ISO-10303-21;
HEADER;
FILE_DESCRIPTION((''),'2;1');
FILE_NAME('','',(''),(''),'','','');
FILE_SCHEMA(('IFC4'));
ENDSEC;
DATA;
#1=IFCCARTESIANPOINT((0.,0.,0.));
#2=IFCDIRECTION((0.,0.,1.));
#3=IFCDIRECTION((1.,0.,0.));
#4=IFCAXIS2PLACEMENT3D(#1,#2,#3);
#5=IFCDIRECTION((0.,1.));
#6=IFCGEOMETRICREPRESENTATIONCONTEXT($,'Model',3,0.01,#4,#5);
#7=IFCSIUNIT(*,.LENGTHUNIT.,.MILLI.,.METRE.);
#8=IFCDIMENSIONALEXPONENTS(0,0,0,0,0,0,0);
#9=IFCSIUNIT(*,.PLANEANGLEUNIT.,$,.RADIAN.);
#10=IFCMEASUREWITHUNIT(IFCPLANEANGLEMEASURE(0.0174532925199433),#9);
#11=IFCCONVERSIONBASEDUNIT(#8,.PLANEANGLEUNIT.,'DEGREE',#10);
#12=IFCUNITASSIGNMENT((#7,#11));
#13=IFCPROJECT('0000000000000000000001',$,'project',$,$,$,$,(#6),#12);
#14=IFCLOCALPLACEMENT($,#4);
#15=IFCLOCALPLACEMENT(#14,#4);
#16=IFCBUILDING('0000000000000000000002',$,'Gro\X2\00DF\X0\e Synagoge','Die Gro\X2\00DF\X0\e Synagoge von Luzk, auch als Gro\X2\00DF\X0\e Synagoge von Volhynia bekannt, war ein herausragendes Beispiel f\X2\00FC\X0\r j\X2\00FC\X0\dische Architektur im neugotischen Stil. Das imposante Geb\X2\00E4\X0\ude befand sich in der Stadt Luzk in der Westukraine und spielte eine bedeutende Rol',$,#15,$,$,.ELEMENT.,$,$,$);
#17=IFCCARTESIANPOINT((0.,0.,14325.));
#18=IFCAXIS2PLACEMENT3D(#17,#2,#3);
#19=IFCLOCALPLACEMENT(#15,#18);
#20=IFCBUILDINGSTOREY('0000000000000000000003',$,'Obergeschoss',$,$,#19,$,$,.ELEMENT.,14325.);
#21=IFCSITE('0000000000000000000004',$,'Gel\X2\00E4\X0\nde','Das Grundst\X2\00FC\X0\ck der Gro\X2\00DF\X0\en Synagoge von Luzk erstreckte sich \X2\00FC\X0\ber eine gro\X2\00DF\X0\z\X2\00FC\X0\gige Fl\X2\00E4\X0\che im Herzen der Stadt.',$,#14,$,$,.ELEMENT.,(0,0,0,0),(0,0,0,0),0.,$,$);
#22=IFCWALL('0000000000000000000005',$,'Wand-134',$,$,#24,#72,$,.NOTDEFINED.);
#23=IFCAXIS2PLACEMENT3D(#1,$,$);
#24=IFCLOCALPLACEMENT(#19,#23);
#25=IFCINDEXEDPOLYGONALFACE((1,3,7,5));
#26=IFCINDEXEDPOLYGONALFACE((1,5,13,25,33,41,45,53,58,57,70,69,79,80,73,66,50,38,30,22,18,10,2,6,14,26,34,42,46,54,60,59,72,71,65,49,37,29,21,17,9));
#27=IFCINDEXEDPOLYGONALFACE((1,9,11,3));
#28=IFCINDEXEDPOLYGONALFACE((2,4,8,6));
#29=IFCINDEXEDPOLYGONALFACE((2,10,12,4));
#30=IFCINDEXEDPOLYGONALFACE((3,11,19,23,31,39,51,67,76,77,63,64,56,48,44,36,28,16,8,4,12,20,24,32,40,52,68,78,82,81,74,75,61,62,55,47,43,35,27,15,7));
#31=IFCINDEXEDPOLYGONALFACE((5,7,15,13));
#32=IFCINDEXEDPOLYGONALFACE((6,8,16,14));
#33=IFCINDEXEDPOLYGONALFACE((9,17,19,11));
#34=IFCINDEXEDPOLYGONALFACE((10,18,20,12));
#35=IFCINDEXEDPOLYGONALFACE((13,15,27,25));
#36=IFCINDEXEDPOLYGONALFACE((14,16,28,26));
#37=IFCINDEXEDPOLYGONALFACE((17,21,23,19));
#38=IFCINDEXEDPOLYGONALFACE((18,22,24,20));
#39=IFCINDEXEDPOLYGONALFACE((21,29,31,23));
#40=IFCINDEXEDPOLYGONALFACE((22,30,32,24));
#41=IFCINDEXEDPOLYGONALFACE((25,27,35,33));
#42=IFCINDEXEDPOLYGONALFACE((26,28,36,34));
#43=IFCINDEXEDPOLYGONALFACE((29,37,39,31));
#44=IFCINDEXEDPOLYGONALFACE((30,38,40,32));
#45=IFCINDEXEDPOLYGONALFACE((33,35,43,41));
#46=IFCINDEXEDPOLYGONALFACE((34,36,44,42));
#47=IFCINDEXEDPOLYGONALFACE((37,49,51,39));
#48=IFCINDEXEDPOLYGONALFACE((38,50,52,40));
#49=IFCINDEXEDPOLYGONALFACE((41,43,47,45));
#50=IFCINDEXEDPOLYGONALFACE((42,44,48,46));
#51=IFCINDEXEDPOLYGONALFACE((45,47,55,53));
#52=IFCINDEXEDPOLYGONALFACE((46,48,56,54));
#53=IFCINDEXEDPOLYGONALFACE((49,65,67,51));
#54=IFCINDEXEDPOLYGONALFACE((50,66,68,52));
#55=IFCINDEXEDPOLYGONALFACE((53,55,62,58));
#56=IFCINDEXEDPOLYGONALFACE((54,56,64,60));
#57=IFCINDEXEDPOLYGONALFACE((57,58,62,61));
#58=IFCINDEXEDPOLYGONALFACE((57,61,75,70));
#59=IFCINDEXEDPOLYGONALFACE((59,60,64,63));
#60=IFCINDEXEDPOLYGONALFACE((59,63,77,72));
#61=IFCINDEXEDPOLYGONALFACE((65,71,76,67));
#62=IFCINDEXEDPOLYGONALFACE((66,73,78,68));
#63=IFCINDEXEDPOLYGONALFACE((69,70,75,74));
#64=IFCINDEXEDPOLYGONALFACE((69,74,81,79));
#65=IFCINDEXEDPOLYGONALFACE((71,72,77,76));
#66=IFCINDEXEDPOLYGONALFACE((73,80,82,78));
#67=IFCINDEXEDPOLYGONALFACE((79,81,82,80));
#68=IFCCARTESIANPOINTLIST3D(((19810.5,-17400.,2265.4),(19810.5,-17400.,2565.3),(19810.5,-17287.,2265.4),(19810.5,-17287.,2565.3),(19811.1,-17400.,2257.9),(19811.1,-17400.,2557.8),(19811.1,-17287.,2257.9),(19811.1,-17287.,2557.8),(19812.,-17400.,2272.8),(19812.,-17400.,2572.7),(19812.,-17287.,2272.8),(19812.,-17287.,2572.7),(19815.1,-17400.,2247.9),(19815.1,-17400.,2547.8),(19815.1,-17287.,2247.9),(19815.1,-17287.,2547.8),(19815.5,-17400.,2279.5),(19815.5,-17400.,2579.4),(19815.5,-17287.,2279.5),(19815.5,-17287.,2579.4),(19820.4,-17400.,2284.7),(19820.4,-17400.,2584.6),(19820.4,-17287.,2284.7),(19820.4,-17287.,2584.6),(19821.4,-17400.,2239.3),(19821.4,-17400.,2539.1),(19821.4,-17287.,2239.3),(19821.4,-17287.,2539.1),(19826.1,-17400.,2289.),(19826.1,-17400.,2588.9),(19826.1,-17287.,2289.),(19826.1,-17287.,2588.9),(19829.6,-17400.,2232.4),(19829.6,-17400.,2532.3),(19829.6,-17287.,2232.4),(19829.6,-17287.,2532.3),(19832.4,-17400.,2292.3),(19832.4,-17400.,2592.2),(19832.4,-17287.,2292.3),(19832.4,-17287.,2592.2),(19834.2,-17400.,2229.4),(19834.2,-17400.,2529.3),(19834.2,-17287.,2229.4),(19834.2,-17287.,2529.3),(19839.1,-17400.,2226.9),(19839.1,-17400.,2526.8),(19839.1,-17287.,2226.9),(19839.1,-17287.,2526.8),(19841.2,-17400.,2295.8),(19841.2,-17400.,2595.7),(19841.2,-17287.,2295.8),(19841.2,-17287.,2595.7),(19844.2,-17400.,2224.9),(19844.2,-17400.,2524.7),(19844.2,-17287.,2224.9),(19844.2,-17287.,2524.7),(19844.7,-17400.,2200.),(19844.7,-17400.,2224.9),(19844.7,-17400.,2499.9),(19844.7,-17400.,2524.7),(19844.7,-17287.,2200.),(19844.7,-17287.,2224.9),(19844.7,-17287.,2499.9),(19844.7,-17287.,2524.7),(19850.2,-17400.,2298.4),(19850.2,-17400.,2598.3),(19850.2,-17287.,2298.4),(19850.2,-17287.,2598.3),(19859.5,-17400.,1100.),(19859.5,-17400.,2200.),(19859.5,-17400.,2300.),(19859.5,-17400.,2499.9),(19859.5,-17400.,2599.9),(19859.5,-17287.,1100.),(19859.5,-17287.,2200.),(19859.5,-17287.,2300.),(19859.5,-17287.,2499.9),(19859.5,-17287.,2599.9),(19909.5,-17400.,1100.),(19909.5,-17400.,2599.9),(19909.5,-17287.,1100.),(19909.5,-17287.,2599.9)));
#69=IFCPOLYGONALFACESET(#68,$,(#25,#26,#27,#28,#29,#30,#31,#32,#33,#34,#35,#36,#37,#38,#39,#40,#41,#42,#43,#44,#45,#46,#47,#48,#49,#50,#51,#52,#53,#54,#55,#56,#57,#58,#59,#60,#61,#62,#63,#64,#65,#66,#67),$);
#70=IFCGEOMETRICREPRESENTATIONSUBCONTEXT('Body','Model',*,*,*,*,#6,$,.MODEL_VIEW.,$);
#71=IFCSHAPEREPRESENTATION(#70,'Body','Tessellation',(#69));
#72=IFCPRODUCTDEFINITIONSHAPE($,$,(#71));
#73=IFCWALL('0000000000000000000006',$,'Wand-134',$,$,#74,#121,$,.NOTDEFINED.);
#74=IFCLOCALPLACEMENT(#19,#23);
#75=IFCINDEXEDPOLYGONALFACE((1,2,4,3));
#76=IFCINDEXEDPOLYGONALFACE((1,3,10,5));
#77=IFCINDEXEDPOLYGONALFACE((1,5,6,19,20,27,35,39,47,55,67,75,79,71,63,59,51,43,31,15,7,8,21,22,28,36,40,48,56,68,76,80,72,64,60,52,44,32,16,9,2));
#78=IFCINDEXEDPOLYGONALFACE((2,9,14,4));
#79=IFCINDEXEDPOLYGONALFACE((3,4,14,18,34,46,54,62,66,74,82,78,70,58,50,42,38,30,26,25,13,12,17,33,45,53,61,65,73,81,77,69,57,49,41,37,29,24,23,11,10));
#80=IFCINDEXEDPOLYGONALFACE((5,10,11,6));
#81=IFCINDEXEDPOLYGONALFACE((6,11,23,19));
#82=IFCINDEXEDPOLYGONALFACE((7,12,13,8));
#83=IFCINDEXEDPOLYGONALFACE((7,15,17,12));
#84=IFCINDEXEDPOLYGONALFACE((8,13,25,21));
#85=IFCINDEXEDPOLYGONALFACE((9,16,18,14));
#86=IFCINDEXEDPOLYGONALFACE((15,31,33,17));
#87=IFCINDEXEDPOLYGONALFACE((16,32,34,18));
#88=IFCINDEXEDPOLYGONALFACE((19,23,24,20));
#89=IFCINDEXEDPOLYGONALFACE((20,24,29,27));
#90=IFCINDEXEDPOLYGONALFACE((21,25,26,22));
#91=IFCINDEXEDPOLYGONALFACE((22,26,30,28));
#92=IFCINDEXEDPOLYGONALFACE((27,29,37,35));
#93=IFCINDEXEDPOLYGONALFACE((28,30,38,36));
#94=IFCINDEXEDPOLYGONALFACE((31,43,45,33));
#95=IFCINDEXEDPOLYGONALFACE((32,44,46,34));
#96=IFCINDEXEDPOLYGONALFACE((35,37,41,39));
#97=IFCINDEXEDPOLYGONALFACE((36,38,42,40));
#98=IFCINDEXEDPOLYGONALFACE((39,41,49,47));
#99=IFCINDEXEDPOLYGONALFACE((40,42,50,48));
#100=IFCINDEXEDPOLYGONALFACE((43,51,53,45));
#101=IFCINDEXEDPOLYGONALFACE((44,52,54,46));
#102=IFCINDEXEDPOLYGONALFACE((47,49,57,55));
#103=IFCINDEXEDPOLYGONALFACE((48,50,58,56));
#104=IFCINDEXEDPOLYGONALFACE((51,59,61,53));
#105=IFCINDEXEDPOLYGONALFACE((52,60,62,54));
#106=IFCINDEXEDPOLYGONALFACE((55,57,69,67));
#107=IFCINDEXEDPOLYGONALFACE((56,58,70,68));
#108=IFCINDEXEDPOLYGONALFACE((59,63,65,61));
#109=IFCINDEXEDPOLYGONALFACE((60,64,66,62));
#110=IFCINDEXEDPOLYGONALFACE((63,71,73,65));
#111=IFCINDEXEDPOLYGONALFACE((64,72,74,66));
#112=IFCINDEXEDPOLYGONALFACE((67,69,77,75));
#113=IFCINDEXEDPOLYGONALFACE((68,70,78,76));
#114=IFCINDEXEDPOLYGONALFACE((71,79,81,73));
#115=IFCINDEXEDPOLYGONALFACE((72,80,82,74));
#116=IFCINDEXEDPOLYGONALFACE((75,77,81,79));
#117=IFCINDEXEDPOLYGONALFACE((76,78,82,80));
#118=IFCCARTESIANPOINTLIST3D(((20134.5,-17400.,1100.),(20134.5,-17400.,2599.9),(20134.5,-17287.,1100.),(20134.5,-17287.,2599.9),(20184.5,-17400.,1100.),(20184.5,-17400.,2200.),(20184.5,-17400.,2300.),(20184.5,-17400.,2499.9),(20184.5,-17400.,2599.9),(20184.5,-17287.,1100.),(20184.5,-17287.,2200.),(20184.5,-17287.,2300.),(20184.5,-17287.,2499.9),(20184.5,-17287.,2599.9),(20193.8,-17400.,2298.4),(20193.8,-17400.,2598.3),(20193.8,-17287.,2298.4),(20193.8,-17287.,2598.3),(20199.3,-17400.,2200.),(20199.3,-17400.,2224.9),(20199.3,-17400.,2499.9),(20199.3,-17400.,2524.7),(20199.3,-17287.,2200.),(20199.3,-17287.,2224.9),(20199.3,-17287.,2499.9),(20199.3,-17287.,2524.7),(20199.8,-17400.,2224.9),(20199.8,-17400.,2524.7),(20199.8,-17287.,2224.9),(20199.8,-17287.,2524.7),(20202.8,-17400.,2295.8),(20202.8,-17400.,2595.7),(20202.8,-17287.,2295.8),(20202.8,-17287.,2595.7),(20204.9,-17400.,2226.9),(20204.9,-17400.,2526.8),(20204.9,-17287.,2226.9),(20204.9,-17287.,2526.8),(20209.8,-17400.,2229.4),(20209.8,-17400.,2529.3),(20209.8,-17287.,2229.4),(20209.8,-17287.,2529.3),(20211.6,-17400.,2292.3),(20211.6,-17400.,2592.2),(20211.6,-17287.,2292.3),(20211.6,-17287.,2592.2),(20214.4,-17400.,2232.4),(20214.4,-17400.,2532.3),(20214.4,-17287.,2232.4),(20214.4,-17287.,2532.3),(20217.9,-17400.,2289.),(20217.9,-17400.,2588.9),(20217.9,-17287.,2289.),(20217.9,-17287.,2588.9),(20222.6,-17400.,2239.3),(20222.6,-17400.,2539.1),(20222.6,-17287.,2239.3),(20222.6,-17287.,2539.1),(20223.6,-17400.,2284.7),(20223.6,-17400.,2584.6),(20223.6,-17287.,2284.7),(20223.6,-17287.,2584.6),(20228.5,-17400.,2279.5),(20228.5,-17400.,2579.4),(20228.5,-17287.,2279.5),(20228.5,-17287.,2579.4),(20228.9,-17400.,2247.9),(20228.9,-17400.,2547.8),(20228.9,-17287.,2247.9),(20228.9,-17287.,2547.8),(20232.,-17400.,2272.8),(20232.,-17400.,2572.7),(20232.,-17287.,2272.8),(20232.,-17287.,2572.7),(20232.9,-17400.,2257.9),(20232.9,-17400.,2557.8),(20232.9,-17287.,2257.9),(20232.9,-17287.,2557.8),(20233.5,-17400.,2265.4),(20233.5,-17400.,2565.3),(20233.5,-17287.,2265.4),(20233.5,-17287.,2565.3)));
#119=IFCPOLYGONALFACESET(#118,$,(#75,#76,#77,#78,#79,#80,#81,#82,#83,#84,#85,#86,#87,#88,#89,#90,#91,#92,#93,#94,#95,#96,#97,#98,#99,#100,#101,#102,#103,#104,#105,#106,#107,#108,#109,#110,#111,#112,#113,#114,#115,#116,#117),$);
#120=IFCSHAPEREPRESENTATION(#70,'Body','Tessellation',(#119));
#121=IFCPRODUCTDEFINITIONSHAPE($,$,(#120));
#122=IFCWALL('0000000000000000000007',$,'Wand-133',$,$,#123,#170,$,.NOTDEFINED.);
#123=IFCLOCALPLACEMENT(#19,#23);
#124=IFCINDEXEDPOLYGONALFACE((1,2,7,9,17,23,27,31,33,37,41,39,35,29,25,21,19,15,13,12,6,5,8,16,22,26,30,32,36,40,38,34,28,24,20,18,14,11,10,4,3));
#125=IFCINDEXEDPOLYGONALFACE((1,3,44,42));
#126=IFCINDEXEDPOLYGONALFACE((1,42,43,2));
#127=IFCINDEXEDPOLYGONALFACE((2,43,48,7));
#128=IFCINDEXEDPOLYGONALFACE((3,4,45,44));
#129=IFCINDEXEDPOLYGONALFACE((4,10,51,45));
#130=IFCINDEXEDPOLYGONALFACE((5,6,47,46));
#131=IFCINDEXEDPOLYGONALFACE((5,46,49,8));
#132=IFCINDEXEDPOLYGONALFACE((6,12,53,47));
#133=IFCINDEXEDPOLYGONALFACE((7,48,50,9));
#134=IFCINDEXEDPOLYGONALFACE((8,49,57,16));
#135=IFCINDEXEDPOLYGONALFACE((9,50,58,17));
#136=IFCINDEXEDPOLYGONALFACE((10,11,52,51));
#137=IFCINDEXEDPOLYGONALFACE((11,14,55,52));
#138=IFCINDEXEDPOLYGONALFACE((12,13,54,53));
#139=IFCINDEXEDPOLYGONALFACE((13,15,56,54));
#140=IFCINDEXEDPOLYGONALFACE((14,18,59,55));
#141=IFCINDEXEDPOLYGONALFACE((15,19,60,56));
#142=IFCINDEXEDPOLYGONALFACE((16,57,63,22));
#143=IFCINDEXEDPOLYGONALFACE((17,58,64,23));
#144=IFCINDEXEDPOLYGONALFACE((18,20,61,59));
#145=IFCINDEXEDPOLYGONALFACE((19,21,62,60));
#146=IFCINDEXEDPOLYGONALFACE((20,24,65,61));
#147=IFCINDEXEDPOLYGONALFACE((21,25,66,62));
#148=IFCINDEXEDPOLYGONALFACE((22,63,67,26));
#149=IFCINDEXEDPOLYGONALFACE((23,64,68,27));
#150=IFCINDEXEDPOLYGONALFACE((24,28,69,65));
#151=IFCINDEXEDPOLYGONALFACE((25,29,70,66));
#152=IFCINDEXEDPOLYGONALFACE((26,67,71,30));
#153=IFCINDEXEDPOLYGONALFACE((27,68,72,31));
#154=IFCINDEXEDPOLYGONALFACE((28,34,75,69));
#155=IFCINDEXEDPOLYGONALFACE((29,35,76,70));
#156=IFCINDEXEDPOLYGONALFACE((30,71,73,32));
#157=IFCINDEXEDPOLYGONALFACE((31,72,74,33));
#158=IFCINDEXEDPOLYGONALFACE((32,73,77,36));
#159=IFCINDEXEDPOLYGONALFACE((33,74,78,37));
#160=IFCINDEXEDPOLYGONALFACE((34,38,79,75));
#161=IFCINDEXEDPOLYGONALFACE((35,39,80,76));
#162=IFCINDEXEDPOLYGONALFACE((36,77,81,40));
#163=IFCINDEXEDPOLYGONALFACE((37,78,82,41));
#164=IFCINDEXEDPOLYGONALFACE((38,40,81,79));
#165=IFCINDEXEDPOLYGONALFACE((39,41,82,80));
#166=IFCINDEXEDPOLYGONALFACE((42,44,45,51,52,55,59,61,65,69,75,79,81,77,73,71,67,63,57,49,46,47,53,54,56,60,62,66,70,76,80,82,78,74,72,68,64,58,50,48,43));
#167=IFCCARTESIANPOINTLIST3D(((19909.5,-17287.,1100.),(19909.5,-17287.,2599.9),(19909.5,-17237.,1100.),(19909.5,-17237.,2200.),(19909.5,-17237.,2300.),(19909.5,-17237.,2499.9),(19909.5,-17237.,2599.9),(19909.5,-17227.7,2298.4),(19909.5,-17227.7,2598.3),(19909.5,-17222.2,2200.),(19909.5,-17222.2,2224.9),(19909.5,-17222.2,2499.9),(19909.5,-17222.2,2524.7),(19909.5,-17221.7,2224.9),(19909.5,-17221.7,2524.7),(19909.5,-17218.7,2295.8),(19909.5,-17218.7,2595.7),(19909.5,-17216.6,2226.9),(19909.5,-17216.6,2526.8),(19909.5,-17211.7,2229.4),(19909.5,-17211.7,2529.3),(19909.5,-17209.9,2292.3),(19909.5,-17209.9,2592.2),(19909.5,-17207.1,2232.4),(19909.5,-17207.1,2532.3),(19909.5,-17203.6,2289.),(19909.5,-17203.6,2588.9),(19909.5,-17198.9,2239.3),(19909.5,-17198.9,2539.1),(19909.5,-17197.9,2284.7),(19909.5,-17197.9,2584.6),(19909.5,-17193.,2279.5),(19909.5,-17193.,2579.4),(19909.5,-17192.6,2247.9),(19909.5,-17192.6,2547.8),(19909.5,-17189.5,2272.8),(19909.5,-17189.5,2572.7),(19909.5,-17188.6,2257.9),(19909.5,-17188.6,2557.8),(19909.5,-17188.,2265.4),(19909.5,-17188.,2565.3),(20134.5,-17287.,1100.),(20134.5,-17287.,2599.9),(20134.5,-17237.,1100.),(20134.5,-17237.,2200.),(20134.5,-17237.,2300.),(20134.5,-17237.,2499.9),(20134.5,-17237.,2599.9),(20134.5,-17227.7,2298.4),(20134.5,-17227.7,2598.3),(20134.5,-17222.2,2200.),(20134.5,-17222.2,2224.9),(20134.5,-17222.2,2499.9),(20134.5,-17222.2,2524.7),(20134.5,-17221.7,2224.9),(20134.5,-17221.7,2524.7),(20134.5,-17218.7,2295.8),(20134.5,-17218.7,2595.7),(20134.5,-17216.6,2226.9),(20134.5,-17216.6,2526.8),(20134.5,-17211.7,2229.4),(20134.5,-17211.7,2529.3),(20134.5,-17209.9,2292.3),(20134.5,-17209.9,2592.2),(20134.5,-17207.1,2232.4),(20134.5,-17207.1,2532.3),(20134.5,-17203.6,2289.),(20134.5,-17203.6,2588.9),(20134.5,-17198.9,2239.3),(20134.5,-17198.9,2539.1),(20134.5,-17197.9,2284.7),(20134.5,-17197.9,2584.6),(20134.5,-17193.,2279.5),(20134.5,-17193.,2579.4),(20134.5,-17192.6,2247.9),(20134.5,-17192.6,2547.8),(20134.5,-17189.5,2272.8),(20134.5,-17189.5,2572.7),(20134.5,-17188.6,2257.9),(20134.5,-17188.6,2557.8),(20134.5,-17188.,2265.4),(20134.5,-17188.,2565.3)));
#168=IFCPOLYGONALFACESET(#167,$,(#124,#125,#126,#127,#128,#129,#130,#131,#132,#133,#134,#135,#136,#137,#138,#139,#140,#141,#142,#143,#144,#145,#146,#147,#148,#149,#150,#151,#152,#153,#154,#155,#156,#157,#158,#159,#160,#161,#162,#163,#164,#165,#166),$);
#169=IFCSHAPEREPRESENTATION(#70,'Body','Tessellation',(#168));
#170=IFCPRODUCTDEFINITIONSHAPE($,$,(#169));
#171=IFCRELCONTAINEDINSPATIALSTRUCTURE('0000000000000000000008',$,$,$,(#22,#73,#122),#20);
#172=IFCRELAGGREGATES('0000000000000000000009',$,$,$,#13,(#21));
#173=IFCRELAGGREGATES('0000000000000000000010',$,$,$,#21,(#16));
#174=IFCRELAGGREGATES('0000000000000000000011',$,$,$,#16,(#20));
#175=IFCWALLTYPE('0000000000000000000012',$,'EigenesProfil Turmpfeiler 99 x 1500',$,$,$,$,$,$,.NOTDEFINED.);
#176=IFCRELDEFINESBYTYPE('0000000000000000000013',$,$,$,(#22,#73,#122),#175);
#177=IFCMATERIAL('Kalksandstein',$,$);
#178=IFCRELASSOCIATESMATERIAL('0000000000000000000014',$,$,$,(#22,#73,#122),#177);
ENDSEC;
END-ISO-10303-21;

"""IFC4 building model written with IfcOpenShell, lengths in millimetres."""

from ifc_helpers import new_model, entity, si_unit, converted_unit, direction, frame, origin_with_axes, place, context, subcontext, project, spatial, line, arc, indexed_curve, outline, extrude, material, material_profile, profile_set, type_object, element, save


model = new_model("IFC4")

# Units and contexts
model_context = context("Model", 3, precision=0.01, world=origin_with_axes(), true_north=direction((0.0, 1.0)))
body_context = subcontext(model_context, "Body", "Model", "MODEL_VIEW")
ifc_project = project(units=[si_unit("LENGTHUNIT", "METRE", prefix="MILLI"), converted_unit("PLANEANGLEUNIT", "DEGREE", entity("IfcPlaneAngleMeasure", 0.0174532925199433), si_unit("PLANEANGLEUNIT", "RADIAN"), dimensions=[0, 0, 0, 0, 0, 0, 0])], contexts=[model_context])

# Site, building, storey
site_placement = place(None, origin_with_axes())
site = spatial("IfcSite", under=ifc_project, at=site_placement, Name="Gelände", Description="Das Grundstück der Großen Synagoge von Luzk erstreckte sich über eine großzügige Fläche im Herzen der Stadt.", CompositionType="ELEMENT", RefLatitude=(0, 0, 0, 0), RefLongitude=(0, 0, 0, 0), RefElevation=0.0)
building_placement = place(site_placement, origin_with_axes())
building = spatial("IfcBuilding", under=site, at=building_placement, Name="Große Synagoge", Description="Die Große Synagoge von Luzk, auch als Große Synagoge von Volhynia bekannt, war ein herausragendes Beispiel für jüdische Architektur im neugotischen Stil. Das imposante Gebäude befand sich in der Stadt Luzk in der Westukraine und spielte eine bedeutende Rol", CompositionType="ELEMENT")
storey_placement = place(building_placement, frame((0.0, 0.0, 14325.0), z_axis=(0.0, 0.0, 1.0), x_axis=(1.0, 0.0, 0.0)))
storey = spatial("IfcBuildingStorey", under=building, at=storey_placement, Name="Obergeschoss", CompositionType="ELEMENT", Elevation=14325.0)

# Walls
ifc_material_1 = material(Name="Kalksandstein")
ifc_material_profile = material_profile(ifc_material_1, outline(indexed_curve([(65.3, 1424.7), (72.9, 1428.0), (79.9, 1432.3), (91.6, 1443.3), (98.4, 1457.8), (98.5, 1469.1), (94.0, 1479.4), (86.3, 1486.9), (77.1, 1492.2), (63.8, 1497.1), (50.0, 1499.9), (0.0, 1499.9), (0.0, 0.0), (50.0, 0.0), (50.0, 1100.0), (64.8, 1100.0), (64.8, 1124.9), (65.3, 1124.9), (72.9, 1128.1), (79.9, 1132.4), (91.6, 1143.4), (98.4, 1157.9), (98.5, 1169.2), (94.0, 1179.5), (86.3, 1187.0), (77.1, 1192.3), (63.8, 1197.2), (50.0, 1200.0), (50.0, 1399.9), (64.8, 1399.9), (64.8, 1424.7)], segments=[arc(1, 2, 3), arc(3, 4, 5), arc(5, 6, 7), arc(7, 8, 9), arc(9, 10, 11), line(11, 12, 13, 14, 15, 16, 17, 18), arc(18, 19, 20), arc(20, 21, 22), arc(22, 23, 24), arc(24, 25, 26), arc(26, 27, 28), line(28, 29, 30, 31, 1)])), Name="Kalksandstein")
ifc_profile_set = profile_set([ifc_material_profile], Name="EigenesProfil Turmpfeiler")
wall_type_1 = type_object("IfcWallType", Name="EigenesProfil Turmpfeiler 99 x 1500", PredefinedType="NOTDEFINED")
wall_1_placement = place(storey_placement, frame((19909.5, -17287.0, 1100.0), z_axis=(0.0, 0.0, 1.0), x_axis=(0.0, -1.0, 0.0)))
element("IfcWall", 1, at=wall_1_placement, inside=storey, type_object=wall_type_1, material=ifc_profile_set, Name="Wand-134", PredefinedType="NOTDEFINED", context=body_context, shape_type="SweptSolid", body=[
    extrude(outline(indexed_curve([(65.3, 1424.7), (72.9, 1428.0), (79.9, 1432.3), (91.6, 1443.3), (98.4, 1457.8), (98.5, 1469.1), (94.0, 1479.4), (86.3, 1486.9), (77.1, 1492.2), (63.8, 1497.1), (50.0, 1499.9), (0.0, 1499.9), (0.0, 0.0), (50.0, 0.0), (50.0, 1100.0), (64.8, 1100.0), (64.8, 1124.9), (65.3, 1124.9), (72.9, 1128.1), (79.9, 1132.4), (91.6, 1143.4), (98.4, 1157.9), (98.5, 1169.2), (94.0, 1179.5), (86.3, 1187.0), (77.1, 1192.3), (63.8, 1197.2), (50.0, 1200.0), (50.0, 1399.9), (64.8, 1399.9), (64.8, 1424.7)], segments=[arc(1, 2, 3), arc(3, 4, 5), arc(5, 6, 7), arc(7, 8, 9), arc(9, 10, 11), line(11, 12, 13, 14, 15, 16, 17, 18), arc(18, 19, 20), arc(20, 21, 22), arc(22, 23, 24), arc(24, 25, 26), arc(26, 27, 28), line(28, 29, 30, 31, 1)])), frame((0.0, 0.0, 0.0), z_axis=(-1.0, 0.0, 0.0), x_axis=(0.0, -1.0, 0.0)), (0.0, 0.0, -1.0), 113.0),
])
wall_2_placement = place(storey_placement, frame((20134.5, -17287.0, 1100.0), z_axis=(0.0, 0.0, 1.0), x_axis=(0.0, -1.0, 0.0)))
element("IfcWall", 2, at=wall_2_placement, inside=storey, type_object=wall_type_1, material=ifc_profile_set, Name="Wand-134", PredefinedType="NOTDEFINED", context=body_context, shape_type="SweptSolid", body=[
    extrude(outline(indexed_curve([(65.3, 1424.7), (72.9, 1428.0), (79.9, 1432.3), (91.6, 1443.3), (98.4, 1457.8), (98.5, 1469.1), (94.0, 1479.4), (86.3, 1486.9), (77.1, 1492.2), (63.8, 1497.1), (50.0, 1499.9), (0.0, 1499.9), (0.0, 0.0), (50.0, 0.0), (50.0, 1100.0), (64.8, 1100.0), (64.8, 1124.9), (65.3, 1124.9), (72.9, 1128.1), (79.9, 1132.4), (91.6, 1143.4), (98.4, 1157.9), (98.5, 1169.2), (94.0, 1179.5), (86.3, 1187.0), (77.1, 1192.3), (63.8, 1197.2), (50.0, 1200.0), (50.0, 1399.9), (64.8, 1399.9), (64.8, 1424.7)], segments=[arc(1, 2, 3), arc(3, 4, 5), arc(5, 6, 7), arc(7, 8, 9), arc(9, 10, 11), line(11, 12, 13, 14, 15, 16, 17, 18), arc(18, 19, 20), arc(20, 21, 22), arc(22, 23, 24), arc(24, 25, 26), arc(26, 27, 28), line(28, 29, 30, 31, 1)])), frame((0.0, 0.0, 0.0), z_axis=(1.0, 0.0, 0.0), x_axis=(0.0, 1.0, 0.0)), (0.0, 0.0, 1.0), 113.0),
])
wall_3_placement = place(storey_placement, frame((19909.5, -17287.0, 1100.0), z_axis=(0.0, 0.0, 1.0), x_axis=(1.0, 0.0, 0.0)))
element("IfcWall", 3, at=wall_3_placement, inside=storey, type_object=wall_type_1, material=ifc_profile_set, Name="Wand-133", PredefinedType="NOTDEFINED", context=body_context, shape_type="SweptSolid", body=[
    extrude(outline(indexed_curve([(65.3, 1424.7), (72.9, 1428.0), (79.9, 1432.3), (91.6, 1443.3), (98.4, 1457.8), (98.5, 1469.1), (94.0, 1479.4), (86.3, 1486.9), (77.1, 1492.2), (63.8, 1497.1), (50.0, 1499.9), (0.0, 1499.9), (0.0, 0.0), (50.0, 0.0), (50.0, 1100.0), (64.8, 1100.0), (64.8, 1124.9), (65.3, 1124.9), (72.9, 1128.1), (79.9, 1132.4), (91.6, 1143.4), (98.4, 1157.9), (98.5, 1169.2), (94.0, 1179.5), (86.3, 1187.0), (77.1, 1192.3), (63.8, 1197.2), (50.0, 1200.0), (50.0, 1399.9), (64.8, 1399.9), (64.8, 1424.7)], segments=[arc(1, 2, 3), arc(3, 4, 5), arc(5, 6, 7), arc(7, 8, 9), arc(9, 10, 11), line(11, 12, 13, 14, 15, 16, 17, 18), arc(18, 19, 20), arc(20, 21, 22), arc(22, 23, 24), arc(24, 25, 26), arc(26, 27, 28), line(28, 29, 30, 31, 1)])), frame((0.0, 0.0, 0.0), z_axis=(1.0, 0.0, 0.0), x_axis=(0.0, 1.0, 0.0)), (0.0, 0.0, 1.0), 225.0),
])

save(model, "model.ifc")
